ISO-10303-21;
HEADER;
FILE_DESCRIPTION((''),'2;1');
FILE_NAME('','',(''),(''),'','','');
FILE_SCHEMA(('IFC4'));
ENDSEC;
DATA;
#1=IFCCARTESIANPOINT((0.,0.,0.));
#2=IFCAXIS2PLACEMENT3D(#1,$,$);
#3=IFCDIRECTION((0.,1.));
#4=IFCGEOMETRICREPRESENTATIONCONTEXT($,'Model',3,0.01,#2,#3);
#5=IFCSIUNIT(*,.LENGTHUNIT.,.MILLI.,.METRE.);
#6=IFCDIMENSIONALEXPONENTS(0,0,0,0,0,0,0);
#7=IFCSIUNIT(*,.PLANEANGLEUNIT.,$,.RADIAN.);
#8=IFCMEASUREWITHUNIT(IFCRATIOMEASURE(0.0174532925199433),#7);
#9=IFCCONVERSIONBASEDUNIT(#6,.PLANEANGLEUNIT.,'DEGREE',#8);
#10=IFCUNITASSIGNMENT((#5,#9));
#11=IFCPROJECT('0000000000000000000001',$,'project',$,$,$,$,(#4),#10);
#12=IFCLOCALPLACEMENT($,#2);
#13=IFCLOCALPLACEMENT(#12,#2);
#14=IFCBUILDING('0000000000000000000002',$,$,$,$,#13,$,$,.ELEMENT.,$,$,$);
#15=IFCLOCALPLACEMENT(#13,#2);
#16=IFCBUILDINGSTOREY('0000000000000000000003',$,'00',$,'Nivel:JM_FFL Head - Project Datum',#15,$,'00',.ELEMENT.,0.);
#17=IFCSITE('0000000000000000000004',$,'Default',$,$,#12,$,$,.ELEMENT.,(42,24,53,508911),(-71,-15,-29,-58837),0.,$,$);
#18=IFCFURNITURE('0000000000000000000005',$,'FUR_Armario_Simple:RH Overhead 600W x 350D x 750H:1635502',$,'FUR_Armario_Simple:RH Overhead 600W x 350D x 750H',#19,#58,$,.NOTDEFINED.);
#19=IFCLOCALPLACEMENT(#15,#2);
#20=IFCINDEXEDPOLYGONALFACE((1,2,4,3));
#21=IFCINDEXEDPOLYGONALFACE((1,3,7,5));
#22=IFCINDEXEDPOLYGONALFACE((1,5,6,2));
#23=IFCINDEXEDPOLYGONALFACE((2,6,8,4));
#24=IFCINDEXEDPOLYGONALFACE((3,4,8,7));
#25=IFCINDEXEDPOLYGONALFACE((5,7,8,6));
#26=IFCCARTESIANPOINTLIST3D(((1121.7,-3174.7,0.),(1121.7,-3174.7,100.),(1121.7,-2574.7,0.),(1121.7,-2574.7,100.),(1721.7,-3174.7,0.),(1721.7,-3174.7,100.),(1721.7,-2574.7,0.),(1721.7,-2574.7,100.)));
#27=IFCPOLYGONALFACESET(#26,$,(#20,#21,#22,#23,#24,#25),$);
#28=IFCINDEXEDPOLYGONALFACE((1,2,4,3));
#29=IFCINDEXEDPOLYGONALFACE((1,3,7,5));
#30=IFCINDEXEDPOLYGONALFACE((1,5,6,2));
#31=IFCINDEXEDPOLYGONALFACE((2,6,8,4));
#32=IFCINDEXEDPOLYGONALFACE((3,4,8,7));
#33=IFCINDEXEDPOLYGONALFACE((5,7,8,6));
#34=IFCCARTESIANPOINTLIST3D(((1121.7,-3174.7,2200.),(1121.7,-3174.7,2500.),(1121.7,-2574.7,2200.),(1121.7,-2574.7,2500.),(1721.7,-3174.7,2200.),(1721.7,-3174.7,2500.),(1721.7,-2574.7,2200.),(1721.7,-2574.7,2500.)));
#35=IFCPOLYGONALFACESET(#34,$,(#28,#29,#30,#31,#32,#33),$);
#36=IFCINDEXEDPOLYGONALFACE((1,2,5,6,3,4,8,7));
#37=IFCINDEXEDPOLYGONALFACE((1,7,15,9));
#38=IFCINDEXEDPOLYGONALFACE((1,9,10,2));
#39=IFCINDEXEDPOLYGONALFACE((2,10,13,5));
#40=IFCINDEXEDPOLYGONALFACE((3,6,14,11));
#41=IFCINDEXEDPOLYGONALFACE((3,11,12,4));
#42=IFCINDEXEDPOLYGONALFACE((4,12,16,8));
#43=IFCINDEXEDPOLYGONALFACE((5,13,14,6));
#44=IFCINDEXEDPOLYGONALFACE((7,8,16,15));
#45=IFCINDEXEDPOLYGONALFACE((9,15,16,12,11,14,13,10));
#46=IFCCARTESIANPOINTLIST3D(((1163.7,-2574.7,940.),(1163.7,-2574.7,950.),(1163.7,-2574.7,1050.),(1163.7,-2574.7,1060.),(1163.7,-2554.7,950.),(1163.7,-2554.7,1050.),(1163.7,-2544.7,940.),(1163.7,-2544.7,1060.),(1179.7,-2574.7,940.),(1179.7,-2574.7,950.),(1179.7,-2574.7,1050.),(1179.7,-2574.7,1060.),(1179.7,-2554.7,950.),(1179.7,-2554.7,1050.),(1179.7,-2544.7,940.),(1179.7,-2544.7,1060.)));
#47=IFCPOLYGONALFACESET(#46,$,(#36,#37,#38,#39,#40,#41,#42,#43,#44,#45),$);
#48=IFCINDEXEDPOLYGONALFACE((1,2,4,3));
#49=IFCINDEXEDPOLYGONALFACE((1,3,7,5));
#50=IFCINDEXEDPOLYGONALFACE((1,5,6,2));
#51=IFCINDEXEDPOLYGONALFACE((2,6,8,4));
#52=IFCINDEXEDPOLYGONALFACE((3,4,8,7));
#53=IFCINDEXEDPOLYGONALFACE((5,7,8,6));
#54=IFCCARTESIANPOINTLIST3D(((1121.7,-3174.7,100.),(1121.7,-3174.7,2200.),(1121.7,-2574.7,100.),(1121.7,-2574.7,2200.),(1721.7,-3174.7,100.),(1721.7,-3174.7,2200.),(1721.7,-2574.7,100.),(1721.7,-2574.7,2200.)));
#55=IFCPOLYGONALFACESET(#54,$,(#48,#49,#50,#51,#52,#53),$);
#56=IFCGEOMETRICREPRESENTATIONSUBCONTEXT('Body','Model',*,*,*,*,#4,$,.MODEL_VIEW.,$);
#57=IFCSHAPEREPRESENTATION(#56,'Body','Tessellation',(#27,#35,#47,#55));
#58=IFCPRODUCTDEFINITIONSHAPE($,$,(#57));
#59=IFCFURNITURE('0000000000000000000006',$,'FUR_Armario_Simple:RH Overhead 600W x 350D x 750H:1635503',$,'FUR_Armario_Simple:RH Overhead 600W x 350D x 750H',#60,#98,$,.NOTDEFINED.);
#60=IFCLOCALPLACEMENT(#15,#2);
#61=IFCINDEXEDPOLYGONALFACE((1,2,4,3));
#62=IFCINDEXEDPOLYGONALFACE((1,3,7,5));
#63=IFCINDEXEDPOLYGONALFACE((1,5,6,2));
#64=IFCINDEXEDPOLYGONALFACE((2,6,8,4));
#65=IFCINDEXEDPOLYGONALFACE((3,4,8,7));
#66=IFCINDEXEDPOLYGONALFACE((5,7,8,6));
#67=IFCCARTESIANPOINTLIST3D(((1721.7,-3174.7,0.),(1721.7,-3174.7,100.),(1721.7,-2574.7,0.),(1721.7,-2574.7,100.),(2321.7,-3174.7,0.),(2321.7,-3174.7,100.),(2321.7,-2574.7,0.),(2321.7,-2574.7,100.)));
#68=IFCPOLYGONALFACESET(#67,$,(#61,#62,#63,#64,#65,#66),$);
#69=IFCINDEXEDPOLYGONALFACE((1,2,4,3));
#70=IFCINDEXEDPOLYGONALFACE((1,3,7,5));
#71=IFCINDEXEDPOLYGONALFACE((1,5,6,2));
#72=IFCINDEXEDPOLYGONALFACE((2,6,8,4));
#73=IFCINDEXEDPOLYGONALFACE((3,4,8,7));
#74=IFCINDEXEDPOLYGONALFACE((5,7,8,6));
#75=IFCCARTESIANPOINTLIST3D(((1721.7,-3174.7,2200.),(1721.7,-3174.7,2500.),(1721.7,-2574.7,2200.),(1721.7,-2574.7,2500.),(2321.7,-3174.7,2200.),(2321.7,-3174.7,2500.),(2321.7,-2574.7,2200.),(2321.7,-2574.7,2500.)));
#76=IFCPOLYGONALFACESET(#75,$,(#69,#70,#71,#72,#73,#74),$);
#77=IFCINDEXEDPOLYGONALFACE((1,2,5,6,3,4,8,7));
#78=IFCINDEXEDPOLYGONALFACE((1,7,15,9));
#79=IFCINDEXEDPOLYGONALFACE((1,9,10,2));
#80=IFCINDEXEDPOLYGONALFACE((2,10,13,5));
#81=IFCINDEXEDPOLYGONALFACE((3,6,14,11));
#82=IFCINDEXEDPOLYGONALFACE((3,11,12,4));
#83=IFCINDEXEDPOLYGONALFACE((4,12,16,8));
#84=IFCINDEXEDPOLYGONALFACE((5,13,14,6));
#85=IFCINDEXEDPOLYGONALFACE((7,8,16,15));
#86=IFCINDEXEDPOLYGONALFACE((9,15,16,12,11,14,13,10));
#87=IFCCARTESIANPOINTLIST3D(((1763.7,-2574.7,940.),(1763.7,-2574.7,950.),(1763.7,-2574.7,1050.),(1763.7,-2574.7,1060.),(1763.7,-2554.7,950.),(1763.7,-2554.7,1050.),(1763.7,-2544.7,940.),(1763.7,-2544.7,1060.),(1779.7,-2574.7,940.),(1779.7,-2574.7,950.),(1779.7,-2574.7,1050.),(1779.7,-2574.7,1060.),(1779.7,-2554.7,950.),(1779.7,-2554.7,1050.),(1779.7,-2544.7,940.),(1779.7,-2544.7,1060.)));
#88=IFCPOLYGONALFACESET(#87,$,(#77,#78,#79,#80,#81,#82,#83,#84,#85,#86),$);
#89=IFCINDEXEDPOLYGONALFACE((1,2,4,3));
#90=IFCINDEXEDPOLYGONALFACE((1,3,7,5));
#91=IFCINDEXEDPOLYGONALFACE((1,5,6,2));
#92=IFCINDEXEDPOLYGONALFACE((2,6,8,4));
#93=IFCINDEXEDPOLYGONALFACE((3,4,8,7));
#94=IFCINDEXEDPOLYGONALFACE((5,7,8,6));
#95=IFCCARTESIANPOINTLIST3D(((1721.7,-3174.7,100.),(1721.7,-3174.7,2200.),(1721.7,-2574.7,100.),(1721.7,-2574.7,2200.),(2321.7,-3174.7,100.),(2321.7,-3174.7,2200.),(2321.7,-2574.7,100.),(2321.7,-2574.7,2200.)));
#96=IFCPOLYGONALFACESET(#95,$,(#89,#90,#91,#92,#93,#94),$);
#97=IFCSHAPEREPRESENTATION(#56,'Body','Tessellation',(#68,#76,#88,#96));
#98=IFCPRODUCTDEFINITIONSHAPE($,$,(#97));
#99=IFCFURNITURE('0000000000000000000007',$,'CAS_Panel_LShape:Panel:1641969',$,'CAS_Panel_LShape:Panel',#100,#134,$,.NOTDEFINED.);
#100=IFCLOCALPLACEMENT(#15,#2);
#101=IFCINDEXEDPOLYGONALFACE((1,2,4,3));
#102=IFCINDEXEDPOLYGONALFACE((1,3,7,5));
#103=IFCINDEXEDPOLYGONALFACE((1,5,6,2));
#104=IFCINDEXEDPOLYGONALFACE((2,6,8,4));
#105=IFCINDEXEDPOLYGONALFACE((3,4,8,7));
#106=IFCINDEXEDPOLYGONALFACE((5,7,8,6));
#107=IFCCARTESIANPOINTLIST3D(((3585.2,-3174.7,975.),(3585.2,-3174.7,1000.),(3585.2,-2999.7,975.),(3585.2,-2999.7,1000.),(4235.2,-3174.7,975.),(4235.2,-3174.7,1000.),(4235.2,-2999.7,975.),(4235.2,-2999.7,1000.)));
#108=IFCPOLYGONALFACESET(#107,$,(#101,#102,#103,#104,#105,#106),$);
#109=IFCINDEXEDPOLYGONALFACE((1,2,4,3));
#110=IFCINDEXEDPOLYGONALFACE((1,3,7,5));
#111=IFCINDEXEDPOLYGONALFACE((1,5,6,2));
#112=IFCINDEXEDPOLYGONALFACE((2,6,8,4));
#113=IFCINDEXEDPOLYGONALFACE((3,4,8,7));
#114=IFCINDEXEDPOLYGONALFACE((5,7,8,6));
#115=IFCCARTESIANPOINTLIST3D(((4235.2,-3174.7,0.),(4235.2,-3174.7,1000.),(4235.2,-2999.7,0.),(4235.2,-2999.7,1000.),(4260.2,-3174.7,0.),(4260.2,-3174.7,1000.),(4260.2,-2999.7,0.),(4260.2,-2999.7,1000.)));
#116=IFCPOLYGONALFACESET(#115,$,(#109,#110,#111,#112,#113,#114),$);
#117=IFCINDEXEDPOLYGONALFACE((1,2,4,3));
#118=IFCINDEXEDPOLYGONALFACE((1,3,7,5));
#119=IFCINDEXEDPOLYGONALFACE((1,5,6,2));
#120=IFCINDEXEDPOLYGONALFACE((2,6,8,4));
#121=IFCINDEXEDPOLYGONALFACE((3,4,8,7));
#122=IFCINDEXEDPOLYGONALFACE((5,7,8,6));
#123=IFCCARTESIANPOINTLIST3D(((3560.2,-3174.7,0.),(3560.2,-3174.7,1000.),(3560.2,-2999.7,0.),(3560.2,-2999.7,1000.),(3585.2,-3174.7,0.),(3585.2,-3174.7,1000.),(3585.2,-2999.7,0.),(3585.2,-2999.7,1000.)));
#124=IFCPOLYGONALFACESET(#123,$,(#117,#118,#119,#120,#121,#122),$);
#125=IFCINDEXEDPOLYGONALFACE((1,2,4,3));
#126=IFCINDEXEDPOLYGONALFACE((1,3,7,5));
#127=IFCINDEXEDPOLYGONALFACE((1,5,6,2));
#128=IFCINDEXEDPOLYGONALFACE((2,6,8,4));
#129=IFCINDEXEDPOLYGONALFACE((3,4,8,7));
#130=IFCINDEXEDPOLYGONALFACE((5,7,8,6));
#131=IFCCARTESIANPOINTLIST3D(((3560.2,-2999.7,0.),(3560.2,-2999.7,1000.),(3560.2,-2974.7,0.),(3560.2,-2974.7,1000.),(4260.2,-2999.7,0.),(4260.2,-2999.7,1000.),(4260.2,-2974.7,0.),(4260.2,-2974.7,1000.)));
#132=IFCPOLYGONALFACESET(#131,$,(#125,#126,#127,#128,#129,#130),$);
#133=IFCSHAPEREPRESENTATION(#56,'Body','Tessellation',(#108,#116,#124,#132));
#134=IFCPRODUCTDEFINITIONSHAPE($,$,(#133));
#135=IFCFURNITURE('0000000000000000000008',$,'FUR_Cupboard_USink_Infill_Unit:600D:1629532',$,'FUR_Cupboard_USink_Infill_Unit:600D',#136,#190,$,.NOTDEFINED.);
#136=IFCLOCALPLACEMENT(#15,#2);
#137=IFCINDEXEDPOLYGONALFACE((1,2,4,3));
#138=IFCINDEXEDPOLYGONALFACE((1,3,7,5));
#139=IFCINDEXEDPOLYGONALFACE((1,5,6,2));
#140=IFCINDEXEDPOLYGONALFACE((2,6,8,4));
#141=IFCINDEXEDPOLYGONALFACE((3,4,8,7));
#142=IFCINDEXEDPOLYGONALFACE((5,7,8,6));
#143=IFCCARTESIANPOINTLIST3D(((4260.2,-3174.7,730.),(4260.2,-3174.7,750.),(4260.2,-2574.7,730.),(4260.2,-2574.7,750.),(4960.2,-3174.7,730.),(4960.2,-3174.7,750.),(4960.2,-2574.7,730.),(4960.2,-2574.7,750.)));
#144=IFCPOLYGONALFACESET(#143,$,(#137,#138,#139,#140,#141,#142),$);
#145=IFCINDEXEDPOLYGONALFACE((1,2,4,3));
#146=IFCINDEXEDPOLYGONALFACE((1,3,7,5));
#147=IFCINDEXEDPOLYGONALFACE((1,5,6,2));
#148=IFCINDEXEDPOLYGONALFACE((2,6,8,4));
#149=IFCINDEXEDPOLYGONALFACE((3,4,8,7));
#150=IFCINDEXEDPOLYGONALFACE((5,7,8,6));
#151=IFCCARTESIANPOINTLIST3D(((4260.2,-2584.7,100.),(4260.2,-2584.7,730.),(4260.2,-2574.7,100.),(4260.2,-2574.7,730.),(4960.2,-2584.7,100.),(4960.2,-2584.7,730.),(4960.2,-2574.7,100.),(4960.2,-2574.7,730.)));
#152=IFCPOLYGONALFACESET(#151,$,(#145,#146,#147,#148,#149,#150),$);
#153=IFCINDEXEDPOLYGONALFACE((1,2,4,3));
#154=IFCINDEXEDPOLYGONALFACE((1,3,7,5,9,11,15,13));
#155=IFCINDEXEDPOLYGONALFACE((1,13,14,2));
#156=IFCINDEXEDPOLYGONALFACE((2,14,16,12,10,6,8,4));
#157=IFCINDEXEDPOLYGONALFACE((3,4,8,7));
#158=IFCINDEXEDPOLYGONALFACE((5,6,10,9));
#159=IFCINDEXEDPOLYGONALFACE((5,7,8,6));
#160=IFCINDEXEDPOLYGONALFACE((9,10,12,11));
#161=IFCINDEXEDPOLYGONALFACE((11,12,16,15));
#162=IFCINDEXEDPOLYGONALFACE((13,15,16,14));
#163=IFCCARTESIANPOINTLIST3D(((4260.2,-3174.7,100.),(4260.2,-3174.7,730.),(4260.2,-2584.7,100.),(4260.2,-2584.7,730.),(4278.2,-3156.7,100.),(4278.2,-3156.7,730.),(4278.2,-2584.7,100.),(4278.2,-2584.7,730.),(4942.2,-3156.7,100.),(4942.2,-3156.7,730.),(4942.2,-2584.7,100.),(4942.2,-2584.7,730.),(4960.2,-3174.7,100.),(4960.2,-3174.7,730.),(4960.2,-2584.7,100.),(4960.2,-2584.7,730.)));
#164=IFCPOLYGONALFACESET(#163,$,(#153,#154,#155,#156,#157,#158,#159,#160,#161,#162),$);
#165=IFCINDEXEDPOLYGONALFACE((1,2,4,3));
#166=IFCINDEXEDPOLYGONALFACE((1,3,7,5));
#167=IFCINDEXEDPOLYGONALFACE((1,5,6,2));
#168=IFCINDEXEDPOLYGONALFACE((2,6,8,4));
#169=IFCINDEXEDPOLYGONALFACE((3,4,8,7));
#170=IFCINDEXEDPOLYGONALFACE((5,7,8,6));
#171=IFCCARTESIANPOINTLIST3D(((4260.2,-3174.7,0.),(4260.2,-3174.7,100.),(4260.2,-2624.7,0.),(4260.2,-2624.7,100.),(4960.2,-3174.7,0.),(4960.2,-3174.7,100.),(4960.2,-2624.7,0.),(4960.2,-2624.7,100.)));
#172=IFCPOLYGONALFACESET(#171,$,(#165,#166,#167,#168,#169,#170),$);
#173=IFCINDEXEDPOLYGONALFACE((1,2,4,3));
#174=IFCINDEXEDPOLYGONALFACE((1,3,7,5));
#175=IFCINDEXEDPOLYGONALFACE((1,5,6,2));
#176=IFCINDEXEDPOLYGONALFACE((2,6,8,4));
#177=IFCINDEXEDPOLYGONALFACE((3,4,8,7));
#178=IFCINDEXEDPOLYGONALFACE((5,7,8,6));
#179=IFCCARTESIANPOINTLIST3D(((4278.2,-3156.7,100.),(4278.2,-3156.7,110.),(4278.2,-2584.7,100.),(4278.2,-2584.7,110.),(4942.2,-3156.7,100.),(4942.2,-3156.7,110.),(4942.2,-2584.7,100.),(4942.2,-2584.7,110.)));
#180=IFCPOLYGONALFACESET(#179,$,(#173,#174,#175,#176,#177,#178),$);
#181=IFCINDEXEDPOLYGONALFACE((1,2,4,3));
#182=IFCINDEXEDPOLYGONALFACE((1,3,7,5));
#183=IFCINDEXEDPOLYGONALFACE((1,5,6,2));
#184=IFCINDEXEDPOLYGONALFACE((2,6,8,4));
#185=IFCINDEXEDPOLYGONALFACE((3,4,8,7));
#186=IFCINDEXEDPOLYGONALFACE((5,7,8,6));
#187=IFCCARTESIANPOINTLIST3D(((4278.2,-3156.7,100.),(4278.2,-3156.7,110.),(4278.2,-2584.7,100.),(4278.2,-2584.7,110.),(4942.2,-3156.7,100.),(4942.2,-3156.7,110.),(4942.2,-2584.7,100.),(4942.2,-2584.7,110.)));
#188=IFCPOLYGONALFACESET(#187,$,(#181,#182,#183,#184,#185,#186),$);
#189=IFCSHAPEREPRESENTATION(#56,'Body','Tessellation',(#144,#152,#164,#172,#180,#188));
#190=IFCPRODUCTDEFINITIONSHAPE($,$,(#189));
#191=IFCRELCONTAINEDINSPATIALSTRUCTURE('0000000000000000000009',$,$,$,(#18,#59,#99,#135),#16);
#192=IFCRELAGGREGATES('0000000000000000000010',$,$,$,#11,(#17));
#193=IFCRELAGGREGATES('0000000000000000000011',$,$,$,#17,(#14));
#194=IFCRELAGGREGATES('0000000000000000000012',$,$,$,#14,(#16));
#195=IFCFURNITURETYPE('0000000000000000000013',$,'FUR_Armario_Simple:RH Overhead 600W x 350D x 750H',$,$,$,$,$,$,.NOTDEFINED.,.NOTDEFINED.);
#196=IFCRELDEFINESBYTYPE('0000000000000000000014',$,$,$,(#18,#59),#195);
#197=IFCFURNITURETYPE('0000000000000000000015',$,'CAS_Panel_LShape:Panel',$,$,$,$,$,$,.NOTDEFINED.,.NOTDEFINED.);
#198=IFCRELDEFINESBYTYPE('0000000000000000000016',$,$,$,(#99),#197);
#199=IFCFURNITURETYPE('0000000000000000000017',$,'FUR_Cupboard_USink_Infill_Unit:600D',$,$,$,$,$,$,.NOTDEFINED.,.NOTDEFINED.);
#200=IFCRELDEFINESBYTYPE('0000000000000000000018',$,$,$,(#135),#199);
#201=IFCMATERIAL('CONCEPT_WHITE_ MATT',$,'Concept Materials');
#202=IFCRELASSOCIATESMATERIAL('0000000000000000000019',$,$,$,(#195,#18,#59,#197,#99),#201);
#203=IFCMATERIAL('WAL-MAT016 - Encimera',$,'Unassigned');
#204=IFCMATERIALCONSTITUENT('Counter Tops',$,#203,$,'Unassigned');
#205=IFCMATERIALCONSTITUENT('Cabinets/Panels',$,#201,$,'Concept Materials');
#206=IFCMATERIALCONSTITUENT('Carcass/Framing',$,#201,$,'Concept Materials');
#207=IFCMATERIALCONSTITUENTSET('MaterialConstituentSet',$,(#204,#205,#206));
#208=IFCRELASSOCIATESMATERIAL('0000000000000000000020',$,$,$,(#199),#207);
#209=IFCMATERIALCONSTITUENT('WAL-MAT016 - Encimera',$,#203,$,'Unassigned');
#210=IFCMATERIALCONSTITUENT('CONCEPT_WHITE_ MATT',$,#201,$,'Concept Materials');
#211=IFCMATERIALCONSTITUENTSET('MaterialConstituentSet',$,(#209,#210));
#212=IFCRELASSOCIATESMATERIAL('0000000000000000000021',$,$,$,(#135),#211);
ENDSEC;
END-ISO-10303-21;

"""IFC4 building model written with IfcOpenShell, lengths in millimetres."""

from ifc_helpers import new_model, entity, si_unit, converted_unit, direction, frame, origin, place, context, subcontext, project, spatial, indexed_curve, outline, extrude, source, transform, mapped, material, constituent, constituent_set, type_object, type_shapes, element, save


model = new_model("IFC4")

# Units and contexts
model_context = context("Model", 3, precision=0.01, world=origin(), true_north=direction((0.0, 1.0)))
body_context = subcontext(model_context, "Body", "Model", "MODEL_VIEW")
ifc_project = project(units=[si_unit("LENGTHUNIT", "METRE", prefix="MILLI"), converted_unit("PLANEANGLEUNIT", "DEGREE", entity("IfcRatioMeasure", 0.0174532925199433), si_unit("PLANEANGLEUNIT", "RADIAN"), dimensions=[0, 0, 0, 0, 0, 0, 0])], contexts=[model_context])

# Site, building, storey
site_placement = place(None, origin())
site = spatial("IfcSite", under=ifc_project, at=site_placement, Name="Default", CompositionType="ELEMENT", RefLatitude=(42, 24, 53, 508911), RefLongitude=(-71, -15, -29, -58837), RefElevation=0.0)
building_placement = place(site_placement, origin())
building = spatial("IfcBuilding", under=site, at=building_placement, CompositionType="ELEMENT")
storey_placement = place(building_placement, origin())
storey = spatial("IfcBuildingStorey", under=building, at=storey_placement, Name="00", ObjectType="Nivel:JM_FFL Head - Project Datum", LongName="00", CompositionType="ELEMENT", Elevation=0.0)

# Shared definitions
ifc_material_1 = material(Name="CONCEPT_WHITE_ MATT", Category="Concept Materials")

# Furniture
furniture_type_1 = type_object("IfcFurnitureType", Name="FUR_Armario_Simple:RH Overhead 600W x 350D x 750H", AssemblyPlace="NOTDEFINED", PredefinedType="NOTDEFINED", material=ifc_material_1)
shared_shape_1 = source(origin(), body_context, "Body", "SweptSolid", [
    extrude(outline(indexed_curve([(-300.0, -300.0), (300.0, -300.0), (300.0, 300.0), (-300.0, 300.0), (-300.0, -300.0)], self_intersect=False)), frame((300.0, -300.0, 0.0), z_axis=(0.0, 0.0, 1.0), x_axis=(-1.0, 0.0, 0.0)), (0.0, 0.0, 1.0), 100.0),
    extrude(outline(indexed_curve([(-300.0, -300.0), (300.0, -300.0), (300.0, 300.0), (-300.0, 300.0), (-300.0, -300.0)], self_intersect=False)), frame((300.0, -300.0, 2200.0), z_axis=(0.0, 0.0, 1.0), x_axis=(-1.0, 0.0, 0.0)), (0.0, 0.0, 1.0), 300.0),
    extrude(outline(indexed_curve([(-60.0, -17.5), (60.0, -17.5), (60.0, 12.5), (50.0, 12.5), (50.0, -7.5), (-50.0, -7.5), (-50.0, 12.5), (-60.0, 12.5), (-60.0, -17.5)], self_intersect=False)), frame((542.0, -612.5, 1000.0), z_axis=(1.0, 0.0, 0.0), x_axis=(0.0, 0.0, -1.0)), (0.0, 0.0, 1.0), 16.0),
    extrude(outline(indexed_curve([(-300.0, -300.0), (300.0, -300.0), (300.0, 300.0), (-300.0, 300.0), (-300.0, -300.0)], self_intersect=False)), frame((300.0, -300.0, 100.0), z_axis=(0.0, 0.0, 1.0), x_axis=(0.0, 1.0, 0.0)), (0.0, 0.0, 1.0), 2100.0),
])
type_shapes(furniture_type_1, [shared_shape_1])
for number, where, z_axis, x_axis, name in (
    (1, (1721.7, -3174.7, 0.0), (0.0, 0.0, 1.0), (-1.0, 0.0, 0.0), "FUR_Armario_Simple:RH Overhead 600W x 350D x 750H:1635502"),
    (2, (2321.7, -3174.7, 0.0), (0.0, 0.0, 1.0), (-1.0, 0.0, 0.0), "FUR_Armario_Simple:RH Overhead 600W x 350D x 750H:1635503"),
):
    element("IfcFurniture", number, at=place(storey_placement, frame(where, z_axis=z_axis, x_axis=x_axis)), inside=storey, type_object=furniture_type_1, material=ifc_material_1, Name=name, ObjectType="FUR_Armario_Simple:RH Overhead 600W x 350D x 750H", PredefinedType="NOTDEFINED", context=body_context, shape_type="MappedRepresentation", body=[
        mapped(shared_shape_1, transform((0.0, 0.0, 0.0), scale=1.0)),
    ])
furniture_type_2 = type_object("IfcFurnitureType", Name="CAS_Panel_LShape:Panel", AssemblyPlace="NOTDEFINED", PredefinedType="NOTDEFINED", material=ifc_material_1)
shared_shape_2 = source(origin(), body_context, "Body", "SweptSolid", [
    extrude(outline(indexed_curve([(-325.0, -87.5), (325.0, -87.5), (325.0, 87.5), (-325.0, 87.5), (-325.0, -87.5)], self_intersect=False)), frame((350.0, -112.5, 975.0)), (0.0, 0.0, 1.0), 25.0),
    extrude(outline(indexed_curve([(-12.5, -87.5), (12.5, -87.5), (12.5, 87.5), (-12.5, 87.5), (-12.5, -87.5)], self_intersect=False)), frame((687.5, -112.5, 0.0), z_axis=(0.0, 0.0, 1.0), x_axis=(-1.0, 0.0, 0.0)), (0.0, 0.0, 1.0), 1000.0),
    extrude(outline(indexed_curve([(-87.5, -12.5), (87.5, -12.5), (87.5, 12.5), (-87.5, 12.5), (-87.5, -12.5)], self_intersect=False)), frame((12.5, -112.5, 0.0), z_axis=(0.0, 0.0, 1.0), x_axis=(0.0, -1.0, 0.0)), (0.0, 0.0, 1.0), 1000.0),
    extrude(outline(indexed_curve([(-12.5, -350.0), (12.5, -350.0), (12.5, 350.0), (-12.5, 350.0), (-12.5, -350.0)], self_intersect=False)), frame((350.0, -12.5, 0.0), z_axis=(0.0, 0.0, 1.0), x_axis=(0.0, -1.0, 0.0)), (0.0, 0.0, 1.0), 1000.0),
])
type_shapes(furniture_type_2, [shared_shape_2])
furniture_1_placement = place(storey_placement, frame((3560.2, -2974.7, 0.0)))
element("IfcFurniture", 3, at=furniture_1_placement, inside=storey, type_object=furniture_type_2, material=ifc_material_1, Name="CAS_Panel_LShape:Panel:1641969", ObjectType="CAS_Panel_LShape:Panel", PredefinedType="NOTDEFINED", context=body_context, shape_type="MappedRepresentation", body=[
    mapped(shared_shape_2, transform((0.0, 0.0, 0.0), scale=1.0)),
])
ifc_material_2 = material(Name="WAL-MAT016 - Encimera", Category="Unassigned")
ifc_constituent_1 = constituent(ifc_material_2, Name="WAL-MAT016 - Encimera", Category="Unassigned")
ifc_constituent_2 = constituent(ifc_material_1, Name="CONCEPT_WHITE_ MATT", Category="Concept Materials")
ifc_constituent_set_1 = constituent_set(constituents=[ifc_constituent_1, ifc_constituent_2], Name="MaterialConstituentSet")
ifc_constituent_3 = constituent(ifc_material_2, Name="Counter Tops", Category="Unassigned")
ifc_constituent_4 = constituent(ifc_material_1, Name="Cabinets/Panels", Category="Concept Materials")
ifc_constituent_5 = constituent(ifc_material_1, Name="Carcass/Framing", Category="Concept Materials")
ifc_constituent_set_2 = constituent_set(constituents=[ifc_constituent_3, ifc_constituent_4, ifc_constituent_5], Name="MaterialConstituentSet")
furniture_type_3 = type_object("IfcFurnitureType", Name="FUR_Cupboard_USink_Infill_Unit:600D", AssemblyPlace="NOTDEFINED", PredefinedType="NOTDEFINED", material=ifc_constituent_set_2)
shared_shape_3 = source(origin(), body_context, "Body", "SweptSolid", [
    extrude(outline(indexed_curve([(-300.0, -350.0), (300.0, -350.0), (300.0, 350.0), (-300.0, 350.0), (-300.0, -350.0)], self_intersect=False)), frame((44.7, 300.0, 730.0), z_axis=(0.0, 0.0, 1.0), x_axis=(0.0, 1.0, 0.0)), (0.0, 0.0, 1.0), 20.0),
    extrude(outline(indexed_curve([(-5.0, -350.0), (5.0, -350.0), (5.0, 350.0), (-5.0, 350.0), (-5.0, -350.0)], self_intersect=False)), frame((44.7, 595.0, 100.0), z_axis=(0.0, 0.0, 1.0), x_axis=(0.0, 1.0, 0.0)), (0.0, 0.0, 1.0), 630.0),
    extrude(outline(indexed_curve([(-299.5, -350.0), (290.5, -350.0), (290.5, -332.0), (-281.5, -332.0), (-281.5, 332.0), (290.5, 332.0), (290.5, 350.0), (-299.5, 350.0), (-299.5, -350.0)], self_intersect=False)), frame((44.7, 299.5, 100.0), z_axis=(0.0, 0.0, 1.0), x_axis=(0.0, 1.0, 0.0)), (0.0, 0.0, 1.0), 630.0),
    extrude(outline(indexed_curve([(-275.0, -350.0), (275.0, -350.0), (275.0, 350.0), (-275.0, 350.0), (-275.0, -350.0)], self_intersect=False)), frame((44.7, 275.0, 0.0), z_axis=(0.0, 0.0, 1.0), x_axis=(0.0, 1.0, 0.0)), (0.0, 0.0, 1.0), 100.0),
    extrude(outline(indexed_curve([(-286.0, -332.0), (286.0, -332.0), (286.0, 332.0), (-286.0, 332.0), (-286.0, -332.0)], self_intersect=False)), frame((44.7, 304.0, 100.0), z_axis=(0.0, 0.0, 1.0), x_axis=(0.0, 1.0, 0.0)), (0.0, 0.0, 1.0), 10.0),
    extrude(outline(indexed_curve([(-286.0, -332.0), (286.0, -332.0), (286.0, 332.0), (-286.0, 332.0), (-286.0, -332.0)], self_intersect=False)), frame((44.7, 304.0, 100.0), z_axis=(0.0, 0.0, 1.0), x_axis=(0.0, 1.0, 0.0)), (0.0, 0.0, 1.0), 10.0),
])
type_shapes(furniture_type_3, [shared_shape_3])
furniture_2_placement = place(storey_placement, frame((4565.5, -3174.7, 0.0)))
element("IfcFurniture", 4, at=furniture_2_placement, inside=storey, type_object=furniture_type_3, material=ifc_constituent_set_1, Name="FUR_Cupboard_USink_Infill_Unit:600D:1629532", ObjectType="FUR_Cupboard_USink_Infill_Unit:600D", PredefinedType="NOTDEFINED", context=body_context, shape_type="MappedRepresentation", body=[
    mapped(shared_shape_3, transform((0.0, 0.0, 0.0), scale=1.0)),
])

save(model, "model.ifc")
